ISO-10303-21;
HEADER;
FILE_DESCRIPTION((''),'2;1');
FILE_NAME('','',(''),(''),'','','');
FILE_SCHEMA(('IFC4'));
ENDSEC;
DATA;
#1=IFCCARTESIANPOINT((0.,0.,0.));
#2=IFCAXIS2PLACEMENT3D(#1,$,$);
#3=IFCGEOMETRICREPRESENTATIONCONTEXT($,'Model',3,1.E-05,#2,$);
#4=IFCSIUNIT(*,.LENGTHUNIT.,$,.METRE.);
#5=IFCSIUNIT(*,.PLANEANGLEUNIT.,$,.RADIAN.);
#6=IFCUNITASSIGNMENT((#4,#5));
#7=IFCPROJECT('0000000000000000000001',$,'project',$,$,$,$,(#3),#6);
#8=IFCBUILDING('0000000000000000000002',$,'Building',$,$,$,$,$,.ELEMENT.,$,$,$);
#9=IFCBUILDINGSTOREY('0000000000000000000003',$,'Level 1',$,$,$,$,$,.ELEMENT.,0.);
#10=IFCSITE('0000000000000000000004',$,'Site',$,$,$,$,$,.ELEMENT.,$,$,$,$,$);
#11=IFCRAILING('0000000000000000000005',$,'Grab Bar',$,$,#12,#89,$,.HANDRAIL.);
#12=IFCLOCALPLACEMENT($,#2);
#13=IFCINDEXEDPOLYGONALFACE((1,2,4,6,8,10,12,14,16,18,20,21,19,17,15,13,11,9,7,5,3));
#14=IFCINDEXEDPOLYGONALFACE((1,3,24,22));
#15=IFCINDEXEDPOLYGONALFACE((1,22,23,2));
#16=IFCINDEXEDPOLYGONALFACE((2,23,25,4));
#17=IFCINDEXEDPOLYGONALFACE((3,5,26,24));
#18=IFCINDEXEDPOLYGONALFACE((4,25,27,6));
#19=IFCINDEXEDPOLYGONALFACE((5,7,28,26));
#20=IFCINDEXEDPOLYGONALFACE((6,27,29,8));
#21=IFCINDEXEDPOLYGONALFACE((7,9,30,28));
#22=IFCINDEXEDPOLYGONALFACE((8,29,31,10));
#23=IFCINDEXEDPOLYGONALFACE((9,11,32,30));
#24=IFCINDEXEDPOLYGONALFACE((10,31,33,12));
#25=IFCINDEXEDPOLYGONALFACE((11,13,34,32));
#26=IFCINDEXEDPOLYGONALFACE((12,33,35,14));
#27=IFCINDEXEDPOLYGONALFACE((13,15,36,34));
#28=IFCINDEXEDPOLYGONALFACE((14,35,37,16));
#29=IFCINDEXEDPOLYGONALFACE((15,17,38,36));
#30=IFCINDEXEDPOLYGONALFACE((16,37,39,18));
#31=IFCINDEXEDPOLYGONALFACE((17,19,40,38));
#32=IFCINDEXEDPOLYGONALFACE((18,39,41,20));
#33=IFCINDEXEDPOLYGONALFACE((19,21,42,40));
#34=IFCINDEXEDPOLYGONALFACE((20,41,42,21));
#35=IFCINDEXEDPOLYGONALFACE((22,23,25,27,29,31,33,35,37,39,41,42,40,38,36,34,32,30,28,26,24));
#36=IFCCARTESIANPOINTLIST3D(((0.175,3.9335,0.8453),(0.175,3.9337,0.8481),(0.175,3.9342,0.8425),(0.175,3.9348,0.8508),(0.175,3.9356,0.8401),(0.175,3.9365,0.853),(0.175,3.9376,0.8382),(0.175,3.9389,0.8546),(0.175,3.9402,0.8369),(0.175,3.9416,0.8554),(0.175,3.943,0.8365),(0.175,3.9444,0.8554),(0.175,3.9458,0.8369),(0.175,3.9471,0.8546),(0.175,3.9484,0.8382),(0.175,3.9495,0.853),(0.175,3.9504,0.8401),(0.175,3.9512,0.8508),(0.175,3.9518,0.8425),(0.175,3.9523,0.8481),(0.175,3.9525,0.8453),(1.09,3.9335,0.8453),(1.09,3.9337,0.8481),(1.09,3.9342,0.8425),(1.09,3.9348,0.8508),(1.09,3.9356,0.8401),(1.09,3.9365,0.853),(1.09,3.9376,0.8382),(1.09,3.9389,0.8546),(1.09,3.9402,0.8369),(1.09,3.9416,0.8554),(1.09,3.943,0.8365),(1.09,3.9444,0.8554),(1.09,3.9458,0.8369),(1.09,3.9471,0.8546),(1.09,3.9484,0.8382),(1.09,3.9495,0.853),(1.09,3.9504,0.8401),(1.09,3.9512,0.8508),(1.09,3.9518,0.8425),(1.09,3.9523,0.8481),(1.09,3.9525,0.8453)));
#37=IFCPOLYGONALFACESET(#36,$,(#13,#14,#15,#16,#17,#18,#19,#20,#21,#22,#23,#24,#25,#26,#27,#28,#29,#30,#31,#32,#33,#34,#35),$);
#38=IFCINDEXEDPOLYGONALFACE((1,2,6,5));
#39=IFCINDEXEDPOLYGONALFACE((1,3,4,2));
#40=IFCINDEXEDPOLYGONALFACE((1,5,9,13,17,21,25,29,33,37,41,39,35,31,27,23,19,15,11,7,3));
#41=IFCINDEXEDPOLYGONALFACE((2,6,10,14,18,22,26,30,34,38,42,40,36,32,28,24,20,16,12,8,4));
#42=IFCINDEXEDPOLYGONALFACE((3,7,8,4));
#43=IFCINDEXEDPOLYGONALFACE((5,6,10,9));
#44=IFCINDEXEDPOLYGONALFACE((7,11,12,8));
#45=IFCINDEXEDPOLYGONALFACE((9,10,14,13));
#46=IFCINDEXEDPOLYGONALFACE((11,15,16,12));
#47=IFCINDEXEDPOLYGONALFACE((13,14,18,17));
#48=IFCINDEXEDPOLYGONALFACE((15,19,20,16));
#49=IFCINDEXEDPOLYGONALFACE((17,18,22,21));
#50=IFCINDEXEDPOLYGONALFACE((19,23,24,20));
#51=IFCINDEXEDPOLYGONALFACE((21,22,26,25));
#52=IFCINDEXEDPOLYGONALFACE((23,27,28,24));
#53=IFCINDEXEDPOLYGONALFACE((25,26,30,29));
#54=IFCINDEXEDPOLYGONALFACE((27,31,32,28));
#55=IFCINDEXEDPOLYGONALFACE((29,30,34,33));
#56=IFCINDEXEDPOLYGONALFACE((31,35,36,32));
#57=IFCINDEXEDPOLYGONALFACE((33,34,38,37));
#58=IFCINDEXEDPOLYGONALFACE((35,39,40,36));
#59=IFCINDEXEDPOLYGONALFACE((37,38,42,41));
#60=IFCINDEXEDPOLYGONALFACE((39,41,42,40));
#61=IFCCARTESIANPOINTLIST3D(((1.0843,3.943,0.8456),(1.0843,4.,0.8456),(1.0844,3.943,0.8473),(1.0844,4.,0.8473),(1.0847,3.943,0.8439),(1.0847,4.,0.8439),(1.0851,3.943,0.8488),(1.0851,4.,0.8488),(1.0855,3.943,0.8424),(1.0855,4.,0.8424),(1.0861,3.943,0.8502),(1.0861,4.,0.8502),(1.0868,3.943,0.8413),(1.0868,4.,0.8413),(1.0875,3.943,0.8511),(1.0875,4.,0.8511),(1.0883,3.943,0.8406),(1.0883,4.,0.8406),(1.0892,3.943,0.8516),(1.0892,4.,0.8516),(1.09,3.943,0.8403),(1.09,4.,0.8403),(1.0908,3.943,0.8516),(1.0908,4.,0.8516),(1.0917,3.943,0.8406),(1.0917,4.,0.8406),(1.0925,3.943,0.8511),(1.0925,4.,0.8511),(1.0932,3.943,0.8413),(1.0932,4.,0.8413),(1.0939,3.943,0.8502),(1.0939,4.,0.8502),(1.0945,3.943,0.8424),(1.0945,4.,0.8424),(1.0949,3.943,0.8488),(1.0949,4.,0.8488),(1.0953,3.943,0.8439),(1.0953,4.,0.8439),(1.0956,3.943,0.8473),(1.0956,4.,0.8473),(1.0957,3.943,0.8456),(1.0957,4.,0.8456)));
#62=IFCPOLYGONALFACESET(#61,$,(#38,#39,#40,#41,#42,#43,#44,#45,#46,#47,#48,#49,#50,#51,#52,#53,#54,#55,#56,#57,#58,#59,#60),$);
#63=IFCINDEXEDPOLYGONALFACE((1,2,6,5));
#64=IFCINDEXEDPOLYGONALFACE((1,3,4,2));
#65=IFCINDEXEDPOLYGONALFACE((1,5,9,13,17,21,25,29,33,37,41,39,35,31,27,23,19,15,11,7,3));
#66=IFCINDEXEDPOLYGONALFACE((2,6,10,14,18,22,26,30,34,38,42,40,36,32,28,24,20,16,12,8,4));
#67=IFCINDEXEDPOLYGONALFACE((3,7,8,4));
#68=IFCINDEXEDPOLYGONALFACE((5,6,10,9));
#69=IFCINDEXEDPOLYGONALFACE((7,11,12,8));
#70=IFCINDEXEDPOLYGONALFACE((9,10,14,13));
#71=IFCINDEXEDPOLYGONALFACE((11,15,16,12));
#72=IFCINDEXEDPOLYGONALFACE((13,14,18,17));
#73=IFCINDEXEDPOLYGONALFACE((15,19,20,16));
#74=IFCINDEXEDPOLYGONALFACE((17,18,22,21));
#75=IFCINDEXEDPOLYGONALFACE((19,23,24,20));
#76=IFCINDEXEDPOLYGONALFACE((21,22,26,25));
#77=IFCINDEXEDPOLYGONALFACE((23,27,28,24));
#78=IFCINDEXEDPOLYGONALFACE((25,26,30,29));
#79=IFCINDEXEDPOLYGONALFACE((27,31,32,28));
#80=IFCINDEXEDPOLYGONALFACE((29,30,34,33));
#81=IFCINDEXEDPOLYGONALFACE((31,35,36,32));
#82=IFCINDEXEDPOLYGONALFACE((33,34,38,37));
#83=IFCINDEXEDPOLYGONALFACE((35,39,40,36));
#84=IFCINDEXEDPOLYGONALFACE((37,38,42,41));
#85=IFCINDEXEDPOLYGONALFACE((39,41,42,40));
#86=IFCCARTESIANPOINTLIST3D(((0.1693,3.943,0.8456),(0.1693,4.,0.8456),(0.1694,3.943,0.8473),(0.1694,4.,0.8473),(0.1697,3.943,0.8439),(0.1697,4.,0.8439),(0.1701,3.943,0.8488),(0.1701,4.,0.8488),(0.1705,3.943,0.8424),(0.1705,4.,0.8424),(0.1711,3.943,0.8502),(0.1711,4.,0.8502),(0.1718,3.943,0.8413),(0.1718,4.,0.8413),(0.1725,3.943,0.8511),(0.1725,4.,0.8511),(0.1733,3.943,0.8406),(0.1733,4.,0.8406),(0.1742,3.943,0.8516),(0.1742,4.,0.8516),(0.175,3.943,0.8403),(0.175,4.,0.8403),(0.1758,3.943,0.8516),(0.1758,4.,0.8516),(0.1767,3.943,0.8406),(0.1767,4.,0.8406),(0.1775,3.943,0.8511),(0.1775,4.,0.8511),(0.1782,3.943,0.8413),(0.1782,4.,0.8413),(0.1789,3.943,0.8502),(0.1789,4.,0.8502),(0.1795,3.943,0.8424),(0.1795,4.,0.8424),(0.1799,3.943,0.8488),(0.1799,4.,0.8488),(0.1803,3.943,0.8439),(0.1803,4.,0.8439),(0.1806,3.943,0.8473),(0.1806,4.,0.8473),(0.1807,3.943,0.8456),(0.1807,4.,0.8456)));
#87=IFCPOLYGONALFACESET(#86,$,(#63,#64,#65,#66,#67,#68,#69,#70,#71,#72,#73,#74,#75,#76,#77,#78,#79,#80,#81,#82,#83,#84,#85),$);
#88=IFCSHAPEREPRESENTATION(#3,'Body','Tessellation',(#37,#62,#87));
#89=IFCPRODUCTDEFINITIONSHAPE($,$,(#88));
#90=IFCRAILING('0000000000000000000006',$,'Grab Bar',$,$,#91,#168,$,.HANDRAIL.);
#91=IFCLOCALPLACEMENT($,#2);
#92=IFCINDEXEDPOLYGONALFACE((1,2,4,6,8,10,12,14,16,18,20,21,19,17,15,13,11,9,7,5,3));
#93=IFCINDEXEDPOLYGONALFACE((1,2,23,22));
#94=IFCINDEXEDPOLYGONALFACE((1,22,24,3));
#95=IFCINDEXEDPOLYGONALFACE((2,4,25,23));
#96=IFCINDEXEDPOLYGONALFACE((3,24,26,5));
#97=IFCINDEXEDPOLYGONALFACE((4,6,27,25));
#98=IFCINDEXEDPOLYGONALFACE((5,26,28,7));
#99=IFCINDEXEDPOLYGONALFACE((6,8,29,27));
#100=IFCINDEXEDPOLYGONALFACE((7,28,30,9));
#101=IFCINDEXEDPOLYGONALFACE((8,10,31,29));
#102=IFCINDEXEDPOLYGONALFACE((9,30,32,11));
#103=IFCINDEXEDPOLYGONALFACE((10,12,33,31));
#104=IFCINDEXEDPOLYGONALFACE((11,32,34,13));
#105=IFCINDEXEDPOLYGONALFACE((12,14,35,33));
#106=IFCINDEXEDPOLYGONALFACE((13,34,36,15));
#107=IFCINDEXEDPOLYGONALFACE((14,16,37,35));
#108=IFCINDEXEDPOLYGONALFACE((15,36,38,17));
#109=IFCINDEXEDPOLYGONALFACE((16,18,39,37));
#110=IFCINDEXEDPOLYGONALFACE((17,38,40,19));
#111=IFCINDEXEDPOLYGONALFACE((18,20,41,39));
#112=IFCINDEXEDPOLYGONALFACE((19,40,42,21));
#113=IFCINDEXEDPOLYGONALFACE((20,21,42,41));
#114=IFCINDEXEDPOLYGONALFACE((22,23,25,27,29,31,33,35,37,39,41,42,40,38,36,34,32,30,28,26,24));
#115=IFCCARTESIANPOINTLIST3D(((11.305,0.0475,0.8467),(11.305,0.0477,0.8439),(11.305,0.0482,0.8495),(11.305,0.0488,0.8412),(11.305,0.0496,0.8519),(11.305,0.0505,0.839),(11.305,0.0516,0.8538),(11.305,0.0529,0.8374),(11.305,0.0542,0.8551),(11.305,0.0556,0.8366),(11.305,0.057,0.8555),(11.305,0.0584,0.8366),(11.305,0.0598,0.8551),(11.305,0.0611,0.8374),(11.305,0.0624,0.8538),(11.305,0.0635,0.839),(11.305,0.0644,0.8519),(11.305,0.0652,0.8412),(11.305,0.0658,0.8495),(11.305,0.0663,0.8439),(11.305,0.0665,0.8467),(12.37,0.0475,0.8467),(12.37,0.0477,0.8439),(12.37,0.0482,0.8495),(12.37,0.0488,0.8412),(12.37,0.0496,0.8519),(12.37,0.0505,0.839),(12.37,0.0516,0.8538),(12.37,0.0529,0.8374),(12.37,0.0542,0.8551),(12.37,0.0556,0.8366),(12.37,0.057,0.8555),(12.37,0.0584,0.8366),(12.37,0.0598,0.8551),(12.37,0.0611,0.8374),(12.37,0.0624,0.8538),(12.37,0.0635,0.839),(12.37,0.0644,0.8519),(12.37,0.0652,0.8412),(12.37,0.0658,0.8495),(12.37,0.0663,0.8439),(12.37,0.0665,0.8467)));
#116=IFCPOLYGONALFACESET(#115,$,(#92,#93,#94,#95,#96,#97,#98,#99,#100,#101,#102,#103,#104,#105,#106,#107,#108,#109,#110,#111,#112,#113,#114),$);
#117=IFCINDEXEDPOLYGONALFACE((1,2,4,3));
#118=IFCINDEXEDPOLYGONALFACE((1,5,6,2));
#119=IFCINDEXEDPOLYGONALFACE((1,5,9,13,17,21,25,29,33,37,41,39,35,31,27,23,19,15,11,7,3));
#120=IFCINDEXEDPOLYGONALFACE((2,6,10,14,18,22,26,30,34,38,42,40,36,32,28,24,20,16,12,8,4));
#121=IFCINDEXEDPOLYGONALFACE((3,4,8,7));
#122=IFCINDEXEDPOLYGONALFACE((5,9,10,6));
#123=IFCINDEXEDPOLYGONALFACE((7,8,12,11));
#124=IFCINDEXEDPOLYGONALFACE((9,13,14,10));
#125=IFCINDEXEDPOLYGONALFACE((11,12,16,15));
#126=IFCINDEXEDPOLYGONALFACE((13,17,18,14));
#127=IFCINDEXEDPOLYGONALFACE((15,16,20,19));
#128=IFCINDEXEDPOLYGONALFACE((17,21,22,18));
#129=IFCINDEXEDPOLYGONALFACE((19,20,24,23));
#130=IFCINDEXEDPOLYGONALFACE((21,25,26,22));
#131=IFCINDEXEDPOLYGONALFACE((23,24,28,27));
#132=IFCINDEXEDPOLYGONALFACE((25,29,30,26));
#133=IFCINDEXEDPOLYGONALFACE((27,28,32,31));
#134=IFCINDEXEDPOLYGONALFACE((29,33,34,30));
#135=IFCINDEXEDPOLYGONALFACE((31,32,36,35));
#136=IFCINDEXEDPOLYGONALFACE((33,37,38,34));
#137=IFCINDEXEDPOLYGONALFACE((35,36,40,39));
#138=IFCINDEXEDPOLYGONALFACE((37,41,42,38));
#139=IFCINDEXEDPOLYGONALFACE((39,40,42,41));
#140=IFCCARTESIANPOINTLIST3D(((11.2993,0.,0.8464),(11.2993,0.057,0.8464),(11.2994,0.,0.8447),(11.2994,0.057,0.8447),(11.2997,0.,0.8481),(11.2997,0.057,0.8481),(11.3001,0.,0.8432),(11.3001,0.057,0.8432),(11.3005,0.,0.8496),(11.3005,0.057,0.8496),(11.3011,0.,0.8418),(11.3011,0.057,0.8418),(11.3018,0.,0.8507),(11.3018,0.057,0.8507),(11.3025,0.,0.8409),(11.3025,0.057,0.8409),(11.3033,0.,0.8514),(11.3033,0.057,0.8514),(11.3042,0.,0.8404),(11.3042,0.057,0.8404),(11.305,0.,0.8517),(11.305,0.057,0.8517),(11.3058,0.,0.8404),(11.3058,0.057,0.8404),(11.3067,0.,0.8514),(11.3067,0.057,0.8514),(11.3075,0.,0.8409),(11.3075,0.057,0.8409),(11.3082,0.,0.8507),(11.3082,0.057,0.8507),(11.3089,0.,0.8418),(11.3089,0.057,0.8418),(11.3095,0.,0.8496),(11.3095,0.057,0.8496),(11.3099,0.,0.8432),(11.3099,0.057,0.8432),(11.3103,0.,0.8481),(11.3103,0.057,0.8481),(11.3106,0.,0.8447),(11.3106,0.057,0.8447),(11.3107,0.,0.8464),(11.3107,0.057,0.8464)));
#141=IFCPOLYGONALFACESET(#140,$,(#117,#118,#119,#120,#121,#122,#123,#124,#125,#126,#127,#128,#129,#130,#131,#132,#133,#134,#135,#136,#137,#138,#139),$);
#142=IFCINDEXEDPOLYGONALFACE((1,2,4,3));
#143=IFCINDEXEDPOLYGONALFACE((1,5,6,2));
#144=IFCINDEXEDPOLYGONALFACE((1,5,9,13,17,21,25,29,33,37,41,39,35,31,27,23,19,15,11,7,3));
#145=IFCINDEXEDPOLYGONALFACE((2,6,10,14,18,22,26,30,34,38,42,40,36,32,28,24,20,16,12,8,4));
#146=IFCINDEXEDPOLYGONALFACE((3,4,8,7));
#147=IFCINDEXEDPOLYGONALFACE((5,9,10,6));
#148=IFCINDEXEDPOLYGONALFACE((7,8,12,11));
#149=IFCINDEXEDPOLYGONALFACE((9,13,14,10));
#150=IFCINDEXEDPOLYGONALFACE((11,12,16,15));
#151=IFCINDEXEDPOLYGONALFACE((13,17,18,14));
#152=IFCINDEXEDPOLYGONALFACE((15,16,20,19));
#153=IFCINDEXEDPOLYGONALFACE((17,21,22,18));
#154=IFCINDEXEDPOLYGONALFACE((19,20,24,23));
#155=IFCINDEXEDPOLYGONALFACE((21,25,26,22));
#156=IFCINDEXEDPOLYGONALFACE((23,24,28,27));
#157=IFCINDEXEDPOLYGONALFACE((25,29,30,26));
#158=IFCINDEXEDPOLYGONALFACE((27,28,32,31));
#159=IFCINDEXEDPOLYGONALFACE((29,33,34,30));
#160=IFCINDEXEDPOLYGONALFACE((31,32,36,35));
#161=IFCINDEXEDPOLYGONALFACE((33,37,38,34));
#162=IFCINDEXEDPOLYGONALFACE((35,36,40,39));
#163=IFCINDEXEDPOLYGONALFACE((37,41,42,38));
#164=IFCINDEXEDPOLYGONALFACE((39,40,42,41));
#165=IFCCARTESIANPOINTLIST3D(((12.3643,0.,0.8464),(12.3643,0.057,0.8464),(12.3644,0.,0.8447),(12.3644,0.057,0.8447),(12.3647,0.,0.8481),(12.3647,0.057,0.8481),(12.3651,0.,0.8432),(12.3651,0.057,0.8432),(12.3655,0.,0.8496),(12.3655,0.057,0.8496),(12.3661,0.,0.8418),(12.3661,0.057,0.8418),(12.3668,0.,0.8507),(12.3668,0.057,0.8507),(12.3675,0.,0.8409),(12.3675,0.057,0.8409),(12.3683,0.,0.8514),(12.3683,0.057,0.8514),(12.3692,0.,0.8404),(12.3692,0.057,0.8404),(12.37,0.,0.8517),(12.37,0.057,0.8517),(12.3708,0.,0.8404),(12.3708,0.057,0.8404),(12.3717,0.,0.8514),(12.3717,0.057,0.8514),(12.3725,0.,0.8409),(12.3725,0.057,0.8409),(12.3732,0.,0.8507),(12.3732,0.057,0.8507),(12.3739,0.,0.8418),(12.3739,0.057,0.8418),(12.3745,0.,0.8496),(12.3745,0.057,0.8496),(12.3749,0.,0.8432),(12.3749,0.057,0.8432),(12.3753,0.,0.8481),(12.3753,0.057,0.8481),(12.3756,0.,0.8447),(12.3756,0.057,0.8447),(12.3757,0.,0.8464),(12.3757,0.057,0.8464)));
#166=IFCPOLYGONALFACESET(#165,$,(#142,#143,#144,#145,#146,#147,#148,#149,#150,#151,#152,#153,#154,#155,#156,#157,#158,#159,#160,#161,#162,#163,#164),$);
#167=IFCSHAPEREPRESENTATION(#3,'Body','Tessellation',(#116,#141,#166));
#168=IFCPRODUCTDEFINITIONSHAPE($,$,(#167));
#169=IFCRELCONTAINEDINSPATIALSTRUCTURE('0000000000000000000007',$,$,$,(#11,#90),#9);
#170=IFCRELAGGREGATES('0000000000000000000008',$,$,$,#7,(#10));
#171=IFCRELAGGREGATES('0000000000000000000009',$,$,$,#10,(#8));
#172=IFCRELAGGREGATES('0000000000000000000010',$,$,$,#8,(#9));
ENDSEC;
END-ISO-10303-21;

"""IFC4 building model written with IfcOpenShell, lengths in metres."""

from ifc_helpers import new_model, entity, si_unit, origin, place, context, project, spatial, element, save


model = new_model("IFC4")

# Units and contexts
model_context = context("Model", 3, precision=1e-05, world=origin())
ifc_project = project(units=[si_unit("LENGTHUNIT", "METRE"), si_unit("PLANEANGLEUNIT", "RADIAN")], contexts=[model_context])

# Site, building, storey
site = spatial("IfcSite", under=ifc_project, Name="Site", CompositionType="ELEMENT")
building = spatial("IfcBuilding", under=site, Name="Building", CompositionType="ELEMENT")
storey = spatial("IfcBuildingStorey", under=building, Name="Level 1", CompositionType="ELEMENT", Elevation=0.0)

# Railings
railing_1_placement = place(None, origin())
element("IfcRailing", 1, at=railing_1_placement, inside=storey, Name="Grab Bar", PredefinedType="HANDRAIL", context=model_context, shape_type="AdvancedSweptSolid", body=[
    entity("IfcSweptDiskSolid", entity("IfcPolyline", [entity("IfcCartesianPoint", [1.09, 3.943, 0.846]), entity("IfcCartesianPoint", [0.175, 3.943, 0.846])]), 0.0095, None, 0.0, 1.0),
    entity("IfcSweptDiskSolid", entity("IfcPolyline", [entity("IfcCartesianPoint", [1.09, 4.0, 0.846]), entity("IfcCartesianPoint", [1.09, 3.943, 0.846])]), 0.0057, None, 0.0, 1.0),
    entity("IfcSweptDiskSolid", entity("IfcPolyline", [entity("IfcCartesianPoint", [0.175, 4.0, 0.846]), entity("IfcCartesianPoint", [0.175, 3.943, 0.846])]), 0.0057, None, 0.0, 1.0),
])
railing_2_placement = place(None, origin())
element("IfcRailing", 2, at=railing_2_placement, inside=storey, Name="Grab Bar", PredefinedType="HANDRAIL", context=model_context, shape_type="AdvancedSweptSolid", body=[
    entity("IfcSweptDiskSolid", entity("IfcPolyline", [entity("IfcCartesianPoint", [11.305, 0.057, 0.846]), entity("IfcCartesianPoint", [12.37, 0.057, 0.846])]), 0.0095, None, 0.0, 1.0),
    entity("IfcSweptDiskSolid", entity("IfcPolyline", [entity("IfcCartesianPoint", [11.305, 0.0, 0.846]), entity("IfcCartesianPoint", [11.305, 0.057, 0.846])]), 0.0057, None, 0.0, 1.0),
    entity("IfcSweptDiskSolid", entity("IfcPolyline", [entity("IfcCartesianPoint", [12.37, 0.0, 0.846]), entity("IfcCartesianPoint", [12.37, 0.057, 0.846])]), 0.0057, None, 0.0, 1.0),
])

save(model, "model.ifc")
